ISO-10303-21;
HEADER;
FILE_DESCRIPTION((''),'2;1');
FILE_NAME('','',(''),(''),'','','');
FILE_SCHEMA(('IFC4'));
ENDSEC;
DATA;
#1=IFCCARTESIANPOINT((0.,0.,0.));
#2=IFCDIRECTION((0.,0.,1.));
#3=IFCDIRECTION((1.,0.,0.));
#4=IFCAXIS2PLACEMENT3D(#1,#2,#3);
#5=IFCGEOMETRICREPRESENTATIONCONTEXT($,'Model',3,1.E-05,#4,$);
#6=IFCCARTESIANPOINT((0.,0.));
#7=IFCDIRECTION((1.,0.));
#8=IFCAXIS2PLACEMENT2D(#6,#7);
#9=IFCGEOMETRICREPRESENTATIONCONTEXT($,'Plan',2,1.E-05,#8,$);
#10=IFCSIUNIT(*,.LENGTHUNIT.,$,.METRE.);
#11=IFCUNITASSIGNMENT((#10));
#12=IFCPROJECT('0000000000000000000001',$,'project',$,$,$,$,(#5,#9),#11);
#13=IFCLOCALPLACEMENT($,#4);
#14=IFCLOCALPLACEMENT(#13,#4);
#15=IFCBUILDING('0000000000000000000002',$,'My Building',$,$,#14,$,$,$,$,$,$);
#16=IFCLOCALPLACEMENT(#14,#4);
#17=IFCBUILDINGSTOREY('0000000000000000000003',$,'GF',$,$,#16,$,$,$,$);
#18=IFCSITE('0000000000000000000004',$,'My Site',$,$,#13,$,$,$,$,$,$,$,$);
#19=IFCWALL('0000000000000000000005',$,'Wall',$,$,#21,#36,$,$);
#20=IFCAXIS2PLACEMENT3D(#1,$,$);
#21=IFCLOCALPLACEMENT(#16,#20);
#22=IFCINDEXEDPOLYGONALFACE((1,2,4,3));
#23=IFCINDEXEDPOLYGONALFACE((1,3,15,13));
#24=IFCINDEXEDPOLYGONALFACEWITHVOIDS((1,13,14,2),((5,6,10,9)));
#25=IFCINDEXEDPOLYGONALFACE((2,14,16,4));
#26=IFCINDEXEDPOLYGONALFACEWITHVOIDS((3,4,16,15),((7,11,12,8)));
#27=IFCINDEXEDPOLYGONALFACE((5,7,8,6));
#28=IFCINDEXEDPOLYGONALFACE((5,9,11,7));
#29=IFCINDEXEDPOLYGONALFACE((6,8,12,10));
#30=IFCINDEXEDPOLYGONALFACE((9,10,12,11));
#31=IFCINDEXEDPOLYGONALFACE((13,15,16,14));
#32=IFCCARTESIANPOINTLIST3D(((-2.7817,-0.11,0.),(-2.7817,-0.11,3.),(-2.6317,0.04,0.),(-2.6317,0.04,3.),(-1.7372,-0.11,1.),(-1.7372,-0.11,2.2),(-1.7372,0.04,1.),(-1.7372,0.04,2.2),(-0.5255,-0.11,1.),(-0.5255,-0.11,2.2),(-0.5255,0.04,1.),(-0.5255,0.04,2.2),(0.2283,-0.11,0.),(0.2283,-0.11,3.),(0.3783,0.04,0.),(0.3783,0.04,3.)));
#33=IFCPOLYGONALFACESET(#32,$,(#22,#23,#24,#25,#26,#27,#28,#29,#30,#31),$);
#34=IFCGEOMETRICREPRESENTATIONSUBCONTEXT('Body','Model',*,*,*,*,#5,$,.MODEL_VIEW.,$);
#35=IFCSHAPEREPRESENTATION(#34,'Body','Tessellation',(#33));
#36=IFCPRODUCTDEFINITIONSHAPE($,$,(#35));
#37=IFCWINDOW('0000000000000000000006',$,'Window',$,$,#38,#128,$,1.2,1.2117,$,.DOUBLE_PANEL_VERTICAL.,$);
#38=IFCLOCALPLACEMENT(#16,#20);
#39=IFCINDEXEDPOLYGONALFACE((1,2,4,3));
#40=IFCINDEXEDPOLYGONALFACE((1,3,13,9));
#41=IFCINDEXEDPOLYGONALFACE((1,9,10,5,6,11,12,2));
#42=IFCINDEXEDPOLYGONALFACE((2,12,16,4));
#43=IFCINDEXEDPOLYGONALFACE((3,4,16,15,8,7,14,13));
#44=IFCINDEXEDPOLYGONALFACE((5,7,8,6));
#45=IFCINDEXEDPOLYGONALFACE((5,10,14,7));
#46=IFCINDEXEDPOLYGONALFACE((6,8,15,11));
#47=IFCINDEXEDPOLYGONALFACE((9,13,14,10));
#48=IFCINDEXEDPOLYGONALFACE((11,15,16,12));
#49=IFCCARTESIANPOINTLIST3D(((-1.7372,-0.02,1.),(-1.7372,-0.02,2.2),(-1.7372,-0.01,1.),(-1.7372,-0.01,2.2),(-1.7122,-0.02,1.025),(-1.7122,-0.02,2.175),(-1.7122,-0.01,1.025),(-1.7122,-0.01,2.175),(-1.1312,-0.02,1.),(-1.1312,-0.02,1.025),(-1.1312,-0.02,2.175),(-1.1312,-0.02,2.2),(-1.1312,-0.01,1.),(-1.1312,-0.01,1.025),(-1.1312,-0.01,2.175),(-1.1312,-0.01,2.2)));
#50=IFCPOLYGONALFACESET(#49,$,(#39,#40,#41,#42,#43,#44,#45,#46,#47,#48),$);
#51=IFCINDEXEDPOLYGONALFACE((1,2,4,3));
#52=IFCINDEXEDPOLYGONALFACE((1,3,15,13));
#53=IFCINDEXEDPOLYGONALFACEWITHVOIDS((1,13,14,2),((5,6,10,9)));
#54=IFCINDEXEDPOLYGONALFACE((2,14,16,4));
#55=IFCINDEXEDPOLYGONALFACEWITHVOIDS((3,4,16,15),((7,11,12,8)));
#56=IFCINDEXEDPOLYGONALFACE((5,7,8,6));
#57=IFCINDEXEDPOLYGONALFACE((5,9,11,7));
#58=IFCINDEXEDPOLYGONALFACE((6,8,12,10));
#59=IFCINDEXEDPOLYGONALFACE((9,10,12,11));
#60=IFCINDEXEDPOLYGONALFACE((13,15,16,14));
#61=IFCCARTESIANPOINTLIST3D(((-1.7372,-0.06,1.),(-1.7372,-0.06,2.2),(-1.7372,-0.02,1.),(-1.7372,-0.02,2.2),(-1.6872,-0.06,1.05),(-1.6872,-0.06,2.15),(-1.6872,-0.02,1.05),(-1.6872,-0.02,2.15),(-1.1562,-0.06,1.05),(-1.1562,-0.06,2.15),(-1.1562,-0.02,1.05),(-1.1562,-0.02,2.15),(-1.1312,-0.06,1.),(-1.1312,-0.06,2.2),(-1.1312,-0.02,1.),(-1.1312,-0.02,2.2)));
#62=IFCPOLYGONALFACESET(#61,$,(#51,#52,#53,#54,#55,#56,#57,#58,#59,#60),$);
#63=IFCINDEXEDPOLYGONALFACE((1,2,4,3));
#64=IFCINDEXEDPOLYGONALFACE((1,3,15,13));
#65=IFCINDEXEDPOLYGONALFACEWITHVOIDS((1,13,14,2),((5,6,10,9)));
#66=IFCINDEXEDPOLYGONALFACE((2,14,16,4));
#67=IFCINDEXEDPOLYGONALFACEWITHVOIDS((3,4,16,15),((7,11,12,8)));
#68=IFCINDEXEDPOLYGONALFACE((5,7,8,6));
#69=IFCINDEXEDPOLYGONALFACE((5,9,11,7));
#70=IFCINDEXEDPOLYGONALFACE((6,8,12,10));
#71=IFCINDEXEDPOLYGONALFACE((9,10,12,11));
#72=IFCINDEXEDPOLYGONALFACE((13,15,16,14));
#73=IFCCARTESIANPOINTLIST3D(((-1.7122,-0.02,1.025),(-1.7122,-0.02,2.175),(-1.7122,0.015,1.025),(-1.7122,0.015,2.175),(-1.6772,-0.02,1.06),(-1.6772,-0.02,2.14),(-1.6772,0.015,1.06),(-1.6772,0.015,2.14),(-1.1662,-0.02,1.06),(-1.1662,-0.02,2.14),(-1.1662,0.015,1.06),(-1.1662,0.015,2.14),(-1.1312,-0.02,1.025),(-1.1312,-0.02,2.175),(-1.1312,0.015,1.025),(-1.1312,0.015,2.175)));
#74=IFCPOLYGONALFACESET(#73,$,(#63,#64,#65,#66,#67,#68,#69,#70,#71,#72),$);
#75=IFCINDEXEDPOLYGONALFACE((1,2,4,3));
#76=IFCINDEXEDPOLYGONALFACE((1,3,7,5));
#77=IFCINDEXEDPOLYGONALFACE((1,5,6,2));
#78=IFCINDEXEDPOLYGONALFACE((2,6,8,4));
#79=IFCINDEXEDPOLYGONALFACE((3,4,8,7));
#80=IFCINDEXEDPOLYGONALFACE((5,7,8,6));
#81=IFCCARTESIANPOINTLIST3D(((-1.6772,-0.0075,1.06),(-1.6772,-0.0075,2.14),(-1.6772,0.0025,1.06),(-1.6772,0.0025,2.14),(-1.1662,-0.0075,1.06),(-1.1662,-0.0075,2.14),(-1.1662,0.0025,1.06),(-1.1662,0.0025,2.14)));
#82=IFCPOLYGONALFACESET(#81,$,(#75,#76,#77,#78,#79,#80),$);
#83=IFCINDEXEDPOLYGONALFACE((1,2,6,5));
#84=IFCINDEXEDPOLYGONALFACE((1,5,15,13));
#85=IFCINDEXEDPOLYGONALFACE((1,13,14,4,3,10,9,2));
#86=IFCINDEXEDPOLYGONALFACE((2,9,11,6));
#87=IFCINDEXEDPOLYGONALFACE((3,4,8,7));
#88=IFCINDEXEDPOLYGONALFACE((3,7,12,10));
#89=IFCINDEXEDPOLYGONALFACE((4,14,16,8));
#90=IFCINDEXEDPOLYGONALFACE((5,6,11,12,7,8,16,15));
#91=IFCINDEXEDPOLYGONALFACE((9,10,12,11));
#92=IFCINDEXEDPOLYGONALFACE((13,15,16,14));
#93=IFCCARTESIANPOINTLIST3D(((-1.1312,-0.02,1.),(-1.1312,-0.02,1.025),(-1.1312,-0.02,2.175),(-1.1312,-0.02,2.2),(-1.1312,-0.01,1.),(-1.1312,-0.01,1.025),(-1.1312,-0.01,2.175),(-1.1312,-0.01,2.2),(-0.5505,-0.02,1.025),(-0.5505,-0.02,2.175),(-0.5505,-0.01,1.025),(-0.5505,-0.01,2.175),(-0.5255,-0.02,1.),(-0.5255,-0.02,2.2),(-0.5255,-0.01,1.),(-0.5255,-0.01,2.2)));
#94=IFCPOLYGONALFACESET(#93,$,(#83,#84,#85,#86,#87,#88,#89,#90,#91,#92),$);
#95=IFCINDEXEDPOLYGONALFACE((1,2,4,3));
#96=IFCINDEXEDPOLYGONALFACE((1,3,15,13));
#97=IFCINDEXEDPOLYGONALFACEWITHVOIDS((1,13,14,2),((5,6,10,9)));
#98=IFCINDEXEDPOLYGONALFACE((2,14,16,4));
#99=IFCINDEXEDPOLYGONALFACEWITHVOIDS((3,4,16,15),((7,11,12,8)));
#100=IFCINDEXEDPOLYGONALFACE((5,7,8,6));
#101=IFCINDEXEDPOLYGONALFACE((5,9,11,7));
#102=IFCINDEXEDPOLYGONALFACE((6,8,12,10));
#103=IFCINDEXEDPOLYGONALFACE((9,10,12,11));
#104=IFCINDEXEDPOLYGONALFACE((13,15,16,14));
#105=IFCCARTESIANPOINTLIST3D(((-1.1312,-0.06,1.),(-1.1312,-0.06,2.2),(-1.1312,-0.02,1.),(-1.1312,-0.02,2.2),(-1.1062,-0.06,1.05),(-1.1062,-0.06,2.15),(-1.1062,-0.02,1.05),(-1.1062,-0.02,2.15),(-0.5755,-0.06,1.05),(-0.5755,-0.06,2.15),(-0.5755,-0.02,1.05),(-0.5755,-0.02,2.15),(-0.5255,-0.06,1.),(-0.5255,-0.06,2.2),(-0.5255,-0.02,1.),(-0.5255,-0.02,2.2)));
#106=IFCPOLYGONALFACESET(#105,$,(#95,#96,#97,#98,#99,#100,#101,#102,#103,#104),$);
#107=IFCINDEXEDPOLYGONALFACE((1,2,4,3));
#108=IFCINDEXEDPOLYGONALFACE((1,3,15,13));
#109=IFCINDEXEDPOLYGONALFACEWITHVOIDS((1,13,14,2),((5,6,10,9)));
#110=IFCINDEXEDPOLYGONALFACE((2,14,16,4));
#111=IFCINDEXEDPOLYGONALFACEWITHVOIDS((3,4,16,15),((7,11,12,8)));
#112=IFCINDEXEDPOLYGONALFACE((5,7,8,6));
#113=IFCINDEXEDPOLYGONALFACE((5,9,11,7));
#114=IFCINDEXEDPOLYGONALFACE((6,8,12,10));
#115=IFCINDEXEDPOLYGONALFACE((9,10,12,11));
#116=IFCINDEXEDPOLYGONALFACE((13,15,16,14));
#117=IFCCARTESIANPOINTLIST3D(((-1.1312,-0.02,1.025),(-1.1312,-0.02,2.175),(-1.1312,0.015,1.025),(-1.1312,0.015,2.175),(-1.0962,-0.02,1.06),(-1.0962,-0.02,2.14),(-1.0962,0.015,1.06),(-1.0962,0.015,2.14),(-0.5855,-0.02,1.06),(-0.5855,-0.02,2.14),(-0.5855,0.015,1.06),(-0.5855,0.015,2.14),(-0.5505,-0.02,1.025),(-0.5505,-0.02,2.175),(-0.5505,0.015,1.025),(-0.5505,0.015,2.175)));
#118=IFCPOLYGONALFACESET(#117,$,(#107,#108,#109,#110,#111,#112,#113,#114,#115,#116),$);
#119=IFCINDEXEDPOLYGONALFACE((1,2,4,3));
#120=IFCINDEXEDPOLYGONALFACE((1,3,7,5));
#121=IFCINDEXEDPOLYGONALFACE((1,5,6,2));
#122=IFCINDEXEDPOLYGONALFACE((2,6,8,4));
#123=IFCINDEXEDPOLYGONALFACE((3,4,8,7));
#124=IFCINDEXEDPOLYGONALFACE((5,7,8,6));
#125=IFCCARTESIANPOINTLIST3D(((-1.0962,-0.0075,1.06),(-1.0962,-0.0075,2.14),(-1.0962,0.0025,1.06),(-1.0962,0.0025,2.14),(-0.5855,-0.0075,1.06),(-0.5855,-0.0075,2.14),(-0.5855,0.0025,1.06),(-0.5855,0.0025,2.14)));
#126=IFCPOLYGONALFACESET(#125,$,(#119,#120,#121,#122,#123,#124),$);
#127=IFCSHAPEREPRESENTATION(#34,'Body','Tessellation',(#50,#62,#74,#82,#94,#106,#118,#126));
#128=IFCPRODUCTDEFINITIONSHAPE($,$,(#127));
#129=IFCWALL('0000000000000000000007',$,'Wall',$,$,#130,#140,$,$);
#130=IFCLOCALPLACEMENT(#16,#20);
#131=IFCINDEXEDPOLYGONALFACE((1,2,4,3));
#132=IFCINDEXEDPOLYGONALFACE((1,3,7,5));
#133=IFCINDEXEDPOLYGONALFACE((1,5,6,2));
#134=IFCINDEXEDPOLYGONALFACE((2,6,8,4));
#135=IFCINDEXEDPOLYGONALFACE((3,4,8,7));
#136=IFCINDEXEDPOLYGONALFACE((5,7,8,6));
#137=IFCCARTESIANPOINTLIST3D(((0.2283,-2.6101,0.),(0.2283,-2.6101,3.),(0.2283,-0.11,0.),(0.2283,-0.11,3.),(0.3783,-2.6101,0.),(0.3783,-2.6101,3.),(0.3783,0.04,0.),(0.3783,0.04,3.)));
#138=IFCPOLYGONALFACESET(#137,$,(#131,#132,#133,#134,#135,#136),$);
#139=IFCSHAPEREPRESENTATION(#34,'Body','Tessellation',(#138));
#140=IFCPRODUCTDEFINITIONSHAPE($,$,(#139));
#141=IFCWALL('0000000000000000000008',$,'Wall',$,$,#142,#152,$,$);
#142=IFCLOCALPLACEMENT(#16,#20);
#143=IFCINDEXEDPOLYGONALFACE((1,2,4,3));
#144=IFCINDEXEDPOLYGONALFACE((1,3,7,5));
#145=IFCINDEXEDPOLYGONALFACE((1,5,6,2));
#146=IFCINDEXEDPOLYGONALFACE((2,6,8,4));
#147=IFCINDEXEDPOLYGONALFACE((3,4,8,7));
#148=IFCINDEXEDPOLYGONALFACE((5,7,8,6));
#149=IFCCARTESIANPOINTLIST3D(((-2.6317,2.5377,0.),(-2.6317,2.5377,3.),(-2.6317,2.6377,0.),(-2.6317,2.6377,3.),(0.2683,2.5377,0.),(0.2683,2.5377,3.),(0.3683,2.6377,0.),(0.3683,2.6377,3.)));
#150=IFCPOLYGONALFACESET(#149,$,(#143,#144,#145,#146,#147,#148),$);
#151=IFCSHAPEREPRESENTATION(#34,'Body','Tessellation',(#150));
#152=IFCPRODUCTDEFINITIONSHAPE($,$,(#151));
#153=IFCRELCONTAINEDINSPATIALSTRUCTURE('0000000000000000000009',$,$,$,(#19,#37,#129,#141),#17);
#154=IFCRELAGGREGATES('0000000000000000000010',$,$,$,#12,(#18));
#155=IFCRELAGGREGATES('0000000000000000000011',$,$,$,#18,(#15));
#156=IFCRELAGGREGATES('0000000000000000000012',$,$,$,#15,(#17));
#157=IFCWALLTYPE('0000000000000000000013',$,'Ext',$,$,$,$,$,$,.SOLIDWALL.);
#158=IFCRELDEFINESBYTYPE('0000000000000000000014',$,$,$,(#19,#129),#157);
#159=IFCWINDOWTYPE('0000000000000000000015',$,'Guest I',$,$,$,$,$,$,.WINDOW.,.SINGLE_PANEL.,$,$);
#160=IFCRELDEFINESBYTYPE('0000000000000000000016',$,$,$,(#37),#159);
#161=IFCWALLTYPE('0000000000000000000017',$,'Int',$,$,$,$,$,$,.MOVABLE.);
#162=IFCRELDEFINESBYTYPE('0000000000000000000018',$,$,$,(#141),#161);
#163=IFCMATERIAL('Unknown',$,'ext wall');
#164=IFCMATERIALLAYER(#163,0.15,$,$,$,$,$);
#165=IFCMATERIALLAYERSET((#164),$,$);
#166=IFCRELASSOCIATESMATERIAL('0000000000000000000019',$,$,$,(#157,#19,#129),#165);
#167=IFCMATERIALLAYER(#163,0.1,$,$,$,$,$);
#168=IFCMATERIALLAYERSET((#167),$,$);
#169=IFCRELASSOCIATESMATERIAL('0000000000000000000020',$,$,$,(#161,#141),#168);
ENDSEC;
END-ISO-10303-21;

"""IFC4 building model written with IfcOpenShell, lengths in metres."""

from ifc_helpers import new_model, entity, si_unit, frame, origin_with_axes, origin_2d_with_axis, place, context, subcontext, project, spatial, line, indexed_curve, outline, extrude, shape, source, transform, mapped, material, layer, layer_set, layer_usage, type_object, type_shapes, element, fill, save


model = new_model("IFC4")

# Units and contexts
model_context = context("Model", 3, precision=1e-05, world=origin_with_axes())
plan_context = context("Plan", 2, precision=1e-05, world=origin_2d_with_axis())
body_context_1 = subcontext(model_context, "Body", "Model", "MODEL_VIEW")
body_context_2 = subcontext(plan_context, "Body", "Plan", "PLAN_VIEW")
ifc_project = project(units=[si_unit("LENGTHUNIT", "METRE")], contexts=[model_context, plan_context])

# Site, building, storey
site_placement = place(None, origin_with_axes())
site = spatial("IfcSite", under=ifc_project, at=site_placement, Name="My Site")
building_placement = place(site_placement, origin_with_axes())
building = spatial("IfcBuilding", under=site, at=building_placement, Name="My Building")
storey_placement = place(building_placement, origin_with_axes())
storey = spatial("IfcBuildingStorey", under=building, at=storey_placement, Name="GF")

# Shared definitions
ifc_material = material(Name="Unknown", Category="ext wall")

# Shared definitions
ifc_layer_1 = layer(ifc_material, 0.15)
ifc_layer_set_1 = layer_set([ifc_layer_1])
wall_type_1 = type_object("IfcWallType", Name="Ext", PredefinedType="SOLIDWALL", material=ifc_layer_set_1)

# Wall, opening, window
ifc_layer_usage_1 = layer_usage(ifc_layer_set_1, "AXIS2", "POSITIVE", 0.0)
wall_1_placement = place(storey_placement, frame((-2.7817, -0.11, 0.0), z_axis=(0.0, 0.0, 1.0), x_axis=(1.0, 0.0, 0.0)))
wall_1 = element("IfcWall", 1, at=wall_1_placement, inside=storey, type_object=wall_type_1, material=ifc_layer_usage_1, Name="Wall", context=body_context_1, shape_type="SweptSolid", body=[
    extrude(outline(indexed_curve([(0.0, 0.0), (0.15, 0.15), (3.16, 0.15), (3.01, 0.0)], segments=[line(1, 2, 3, 4, 1)])), origin_with_axes(), (0.0, 0.0, 1.0), 3.0),
])
shared_shape_1 = source(origin_with_axes(), body_context_1, "Body", "SweptSolid", [
    extrude(outline(indexed_curve([(0.0, 0.0), (1.2117, 0.0), (1.2117, 1.2), (0.0, 1.2)], segments=[line(1, 2, 3, 4, 1)])), frame((0.0, -0.6, 0.0), z_axis=(0.0, -1.0, 0.0), x_axis=(1.0, 0.0, 0.0)), (0.0, 0.0, -1.0), 1.2),
])
opening_1_placement = place(wall_1_placement, frame((1.0445, 0.0, 1.0), z_axis=(0.0, 0.0, 1.0), x_axis=(1.0, 0.0, 0.0)))
opening_1 = element("IfcOpeningElement", 2, at=opening_1_placement, cuts=wall_1, PredefinedType="OPENING", context=body_context_1, shape_type="MappedRepresentation", body=[
    mapped(shared_shape_1, transform((0.0, 0.0, 0.0), x_axis=(1.0, 0.0, 0.0), y_axis=(0.0, 1.0, 0.0), z_axis=(0.0, 0.0, 1.0), scale=1.0)),
])
window_type_1 = type_object("IfcWindowType", Name="Guest I", PartitioningType="SINGLE_PANEL", PredefinedType="WINDOW")
shared_shape_2 = source(origin_with_axes(), body_context_1, "Body", "SweptSolid", [
    extrude(outline(indexed_curve([(0.606, 0.0), (0.0, 0.0), (0.0, 1.2), (0.606, 1.2), (0.606, 1.175), (0.025, 1.175), (0.025, 0.025), (0.606, 0.025)], segments=[line(1, 2, 3, 4, 5, 6, 7, 8, 1)])), frame((0.0, 0.09, 0.0), z_axis=(0.0, -1.0, 0.0), x_axis=(1.0, 0.0, 0.0)), (0.0, 0.0, -1.0), 0.01),
    extrude(outline(indexed_curve([(0.0, 0.0), (0.606, 0.0), (0.606, 1.2), (0.0, 1.2)], segments=[line(1, 2, 3, 4, 1)]), holes=[indexed_curve([(0.05, 0.05), (0.581, 0.05), (0.581, 1.15), (0.05, 1.15)], segments=[line(1, 2, 3, 4, 1)])]), frame((0.0, 0.05, 0.0), z_axis=(0.0, -1.0, 0.0), x_axis=(1.0, 0.0, 0.0)), (0.0, 0.0, -1.0), 0.04),
    extrude(outline(indexed_curve([(0.0, 0.0), (0.581, 0.0), (0.581, 1.15), (0.0, 1.15)], segments=[line(1, 2, 3, 4, 1)]), holes=[indexed_curve([(0.035, 0.035), (0.546, 0.035), (0.546, 1.115), (0.035, 1.115)], segments=[line(1, 2, 3, 4, 1)])]), frame((0.025, 0.09, 0.025), z_axis=(0.0, -1.0, 0.0), x_axis=(1.0, 0.0, 0.0)), (0.0, 0.0, -1.0), 0.035),
    extrude(outline(indexed_curve([(0.035, 0.035), (0.546, 0.035), (0.546, 1.115), (0.035, 1.115)], segments=[line(1, 2, 3, 4, 1)])), frame((0.025, 0.1025, 0.025), z_axis=(0.0, -1.0, 0.0), x_axis=(1.0, 0.0, 0.0)), (0.0, 0.0, -1.0), 0.01),
    extrude(outline(indexed_curve([(0.0, 1.2), (0.6057, 1.2), (0.6057, 0.0), (0.0, 0.0), (0.0, 0.025), (0.5807, 0.025), (0.5807, 1.175), (0.0, 1.175)], segments=[line(1, 2, 3, 4, 5, 6, 7, 8, 1)])), frame((0.606, 0.09, 0.0), z_axis=(0.0, -1.0, 0.0), x_axis=(1.0, 0.0, 0.0)), (0.0, 0.0, -1.0), 0.01),
    extrude(outline(indexed_curve([(0.0, 0.0), (0.6057, 0.0), (0.6057, 1.2), (0.0, 1.2)], segments=[line(1, 2, 3, 4, 1)]), holes=[indexed_curve([(0.025, 0.05), (0.5557, 0.05), (0.5557, 1.15), (0.025, 1.15)], segments=[line(1, 2, 3, 4, 1)])]), frame((0.606, 0.05, 0.0), z_axis=(0.0, -1.0, 0.0), x_axis=(1.0, 0.0, 0.0)), (0.0, 0.0, -1.0), 0.04),
    extrude(outline(indexed_curve([(0.0, 0.0), (0.5807, 0.0), (0.5807, 1.15), (0.0, 1.15)], segments=[line(1, 2, 3, 4, 1)]), holes=[indexed_curve([(0.035, 0.035), (0.5457, 0.035), (0.5457, 1.115), (0.035, 1.115)], segments=[line(1, 2, 3, 4, 1)])]), frame((0.606, 0.09, 0.025), z_axis=(0.0, -1.0, 0.0), x_axis=(1.0, 0.0, 0.0)), (0.0, 0.0, -1.0), 0.035),
    extrude(outline(indexed_curve([(0.035, 0.035), (0.5457, 0.035), (0.5457, 1.115), (0.035, 1.115)], segments=[line(1, 2, 3, 4, 1)])), frame((0.606, 0.1025, 0.025), z_axis=(0.0, -1.0, 0.0), x_axis=(1.0, 0.0, 0.0)), (0.0, 0.0, -1.0), 0.01),
])
shared_shape_3 = source(origin_with_axes(), body_context_2, "Body", "Curve2D", [
    entity("IfcIndexedPolyCurve", entity("IfcCartesianPointList2D", [[0.05, 0.05], [0.581, 0.05]])),
    entity("IfcIndexedPolyCurve", entity("IfcCartesianPointList2D", [[0.0, 0.1], [0.025, 0.1], [0.025, 0.09], [0.05, 0.09], [0.05, 0.05], [0.0, 0.05]]), [entity("IfcLineIndex", [1, 2, 3, 4, 5, 6, 1])]),
    entity("IfcIndexedPolyCurve", entity("IfcCartesianPointList2D", [[0.606, 0.1], [0.606, 0.1], [0.606, 0.09], [0.581, 0.09], [0.581, 0.05], [0.606, 0.05]])),
    entity("IfcIndexedPolyCurve", entity("IfcCartesianPointList2D", [[0.025, 0.09], [0.06, 0.09], [0.06, 0.125], [0.025, 0.125]]), [entity("IfcLineIndex", [1, 2, 3, 4, 1])]),
    entity("IfcIndexedPolyCurve", entity("IfcCartesianPointList2D", [[0.606, 0.09], [0.571, 0.09], [0.571, 0.125], [0.606, 0.125]]), [entity("IfcLineIndex", [1, 2, 3, 4, 1])]),
    entity("IfcIndexedPolyCurve", entity("IfcCartesianPointList2D", [[0.06, 0.09], [0.571, 0.09]])),
    entity("IfcIndexedPolyCurve", entity("IfcCartesianPointList2D", [[0.06, 0.125], [0.571, 0.125]])),
    entity("IfcIndexedPolyCurve", entity("IfcCartesianPointList2D", [[0.06, 0.1075], [0.571, 0.1075]])),
    entity("IfcIndexedPolyCurve", entity("IfcCartesianPointList2D", [[0.631, 0.05], [1.1617, 0.05]])),
    entity("IfcIndexedPolyCurve", entity("IfcCartesianPointList2D", [[0.606, 0.1], [0.606, 0.1], [0.606, 0.09], [0.631, 0.09], [0.631, 0.05], [0.606, 0.05]])),
    entity("IfcIndexedPolyCurve", entity("IfcCartesianPointList2D", [[1.2117, 0.1], [1.1867, 0.1], [1.1867, 0.09], [1.1617, 0.09], [1.1617, 0.05], [1.2117, 0.05]]), [entity("IfcLineIndex", [1, 2, 3, 4, 5, 6, 1])]),
    entity("IfcIndexedPolyCurve", entity("IfcCartesianPointList2D", [[0.606, 0.09], [0.641, 0.09], [0.641, 0.125], [0.606, 0.125]]), [entity("IfcLineIndex", [1, 2, 3, 4, 1])]),
    entity("IfcIndexedPolyCurve", entity("IfcCartesianPointList2D", [[1.1867, 0.09], [1.1517, 0.09], [1.1517, 0.125], [1.1867, 0.125]]), [entity("IfcLineIndex", [1, 2, 3, 4, 1])]),
    entity("IfcIndexedPolyCurve", entity("IfcCartesianPointList2D", [[0.641, 0.09], [1.1517, 0.09]])),
    entity("IfcIndexedPolyCurve", entity("IfcCartesianPointList2D", [[0.641, 0.125], [1.1517, 0.125]])),
    entity("IfcIndexedPolyCurve", entity("IfcCartesianPointList2D", [[0.641, 0.1075], [1.1517, 0.1075]])),
])
type_shapes(window_type_1, [shared_shape_2, shared_shape_3])
window_1_placement = place(opening_1_placement, origin_with_axes())
window_1 = element("IfcWindow", 3, at=window_1_placement, inside=storey, type_object=window_type_1, Name="Window", OverallHeight=1.2, OverallWidth=1.2117, PartitioningType="DOUBLE_PANEL_VERTICAL", shapes=[
    shape(body_context_1, "Body", "MappedRepresentation", [mapped(shared_shape_2, transform((0.0, 0.0, 0.0), x_axis=(1.0, 0.0, 0.0), y_axis=(0.0, 1.0, 0.0), z_axis=(0.0, 0.0, 1.0), scale=1.0))]),
    shape(body_context_2, "Body", "MappedRepresentation", [mapped(shared_shape_3, transform((0.0, 0.0, 0.0), x_axis=(1.0, 0.0, 0.0), y_axis=(0.0, 1.0, 0.0), z_axis=(0.0, 0.0, 1.0), scale=1.0))]),
])
fill(opening_1, window_1)

# Walls
ifc_layer_usage_2 = layer_usage(ifc_layer_set_1, "AXIS2", "POSITIVE", 0.0)
wall_2_placement = place(storey_placement, frame((0.2283, -0.11, 0.0), z_axis=(0.0, 0.0, 1.0), x_axis=(0.0, -1.0, 0.0)))
element("IfcWall", 4, at=wall_2_placement, inside=storey, type_object=wall_type_1, material=ifc_layer_usage_2, Name="Wall", context=body_context_1, shape_type="SweptSolid", body=[
    extrude(outline(indexed_curve([(0.0, 0.0), (-0.15, 0.15), (2.5001, 0.15), (2.5001, 0.0)], segments=[line(1, 2, 3, 4, 1)])), origin_with_axes(), (0.0, 0.0, 1.0), 3.0),
])
ifc_layer_2 = layer(ifc_material, 0.1)
ifc_layer_set_2 = layer_set([ifc_layer_2])
ifc_layer_usage_3 = layer_usage(ifc_layer_set_2, "AXIS2", "POSITIVE", 0.0)
wall_type_2 = type_object("IfcWallType", Name="Int", PredefinedType="MOVABLE", material=ifc_layer_set_2)
wall_3_placement = place(storey_placement, frame((-2.6317, 2.5377, 0.0), z_axis=(0.0, 0.0, 1.0), x_axis=(1.0, 0.0, 0.0)))
element("IfcWall", 5, at=wall_3_placement, inside=storey, type_object=wall_type_2, material=ifc_layer_usage_3, Name="Wall", context=body_context_1, shape_type="SweptSolid", body=[
    extrude(outline(indexed_curve([(0.0, 0.0), (0.0, 0.1), (3.0, 0.1), (2.9, 0.0)], segments=[line(1, 2, 3, 4, 1)])), origin_with_axes(), (0.0, 0.0, 1.0), 3.0),
])

save(model, "model.ifc")
